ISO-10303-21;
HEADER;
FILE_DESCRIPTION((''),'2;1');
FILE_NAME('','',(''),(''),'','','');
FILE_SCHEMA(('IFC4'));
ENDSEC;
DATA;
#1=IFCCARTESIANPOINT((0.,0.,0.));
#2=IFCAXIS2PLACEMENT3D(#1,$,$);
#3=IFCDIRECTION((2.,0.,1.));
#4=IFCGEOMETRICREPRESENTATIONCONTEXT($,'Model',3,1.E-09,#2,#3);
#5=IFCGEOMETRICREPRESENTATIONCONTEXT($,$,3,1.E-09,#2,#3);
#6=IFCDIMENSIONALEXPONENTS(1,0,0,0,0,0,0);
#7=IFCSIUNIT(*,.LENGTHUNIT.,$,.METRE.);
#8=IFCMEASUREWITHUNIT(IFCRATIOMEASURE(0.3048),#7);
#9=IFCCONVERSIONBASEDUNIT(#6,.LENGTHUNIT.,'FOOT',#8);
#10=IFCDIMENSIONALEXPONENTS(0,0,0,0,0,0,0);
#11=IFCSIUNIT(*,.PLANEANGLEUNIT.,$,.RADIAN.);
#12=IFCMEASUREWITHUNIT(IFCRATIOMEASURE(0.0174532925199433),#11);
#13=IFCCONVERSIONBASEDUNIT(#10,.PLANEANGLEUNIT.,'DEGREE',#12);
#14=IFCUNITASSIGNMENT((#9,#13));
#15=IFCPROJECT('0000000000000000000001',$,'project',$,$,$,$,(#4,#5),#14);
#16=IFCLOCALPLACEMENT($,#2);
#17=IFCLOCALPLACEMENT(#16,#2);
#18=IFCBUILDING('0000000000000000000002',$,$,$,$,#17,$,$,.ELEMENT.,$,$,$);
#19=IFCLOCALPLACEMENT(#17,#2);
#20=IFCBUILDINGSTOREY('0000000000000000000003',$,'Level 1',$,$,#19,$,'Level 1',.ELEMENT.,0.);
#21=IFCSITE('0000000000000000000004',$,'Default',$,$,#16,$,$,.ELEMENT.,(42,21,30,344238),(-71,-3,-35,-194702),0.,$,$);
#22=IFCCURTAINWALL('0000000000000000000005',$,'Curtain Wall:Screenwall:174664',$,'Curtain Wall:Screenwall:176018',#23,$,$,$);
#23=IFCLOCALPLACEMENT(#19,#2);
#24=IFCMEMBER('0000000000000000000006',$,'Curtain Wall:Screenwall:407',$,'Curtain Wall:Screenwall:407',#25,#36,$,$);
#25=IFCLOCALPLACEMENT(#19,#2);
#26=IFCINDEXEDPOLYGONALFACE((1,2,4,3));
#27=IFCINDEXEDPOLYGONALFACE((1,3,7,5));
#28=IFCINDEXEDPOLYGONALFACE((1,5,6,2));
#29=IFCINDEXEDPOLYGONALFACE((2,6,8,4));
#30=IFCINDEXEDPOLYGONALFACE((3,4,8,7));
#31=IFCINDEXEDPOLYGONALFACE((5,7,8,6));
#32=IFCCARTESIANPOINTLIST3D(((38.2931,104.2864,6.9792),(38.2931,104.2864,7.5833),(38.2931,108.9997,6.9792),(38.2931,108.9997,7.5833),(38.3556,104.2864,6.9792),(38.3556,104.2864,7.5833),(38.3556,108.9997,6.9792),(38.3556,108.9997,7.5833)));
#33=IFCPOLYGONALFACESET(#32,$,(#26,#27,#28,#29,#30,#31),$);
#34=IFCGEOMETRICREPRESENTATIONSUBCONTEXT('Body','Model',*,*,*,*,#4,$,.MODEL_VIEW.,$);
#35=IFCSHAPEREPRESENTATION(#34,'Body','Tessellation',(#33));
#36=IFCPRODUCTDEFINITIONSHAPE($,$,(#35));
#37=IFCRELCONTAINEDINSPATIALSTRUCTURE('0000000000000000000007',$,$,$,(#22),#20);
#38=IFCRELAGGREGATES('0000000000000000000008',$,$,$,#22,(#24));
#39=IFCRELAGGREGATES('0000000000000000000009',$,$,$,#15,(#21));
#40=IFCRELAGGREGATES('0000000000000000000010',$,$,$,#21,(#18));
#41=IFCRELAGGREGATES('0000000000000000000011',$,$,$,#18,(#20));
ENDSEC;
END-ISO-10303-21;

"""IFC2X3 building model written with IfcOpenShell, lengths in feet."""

from ifc_helpers import new_model, entity, si_unit, converted_unit, direction, frame, origin, origin_2d_with_axis, place, context, subcontext, project, spatial, rectangle, extrude, element, aggregate, save


model = new_model("IFC2X3")

# Units and contexts
model_context = context("Model", 3, precision=1e-09, world=origin(), true_north=direction((2.0, 0.0, 1.0)))
context_of_model = context(None, 3, precision=1e-09, world=origin(), true_north=direction((2.0, 0.0, 1.0)))
body_context = subcontext(model_context, "Body", "Model", "MODEL_VIEW")
ifc_project = project(units=[converted_unit("LENGTHUNIT", "FOOT", entity("IfcRatioMeasure", 0.3048), si_unit("LENGTHUNIT", "METRE"), dimensions=[1, 0, 0, 0, 0, 0, 0]), converted_unit("PLANEANGLEUNIT", "DEGREE", entity("IfcRatioMeasure", 0.0174532925199433), si_unit("PLANEANGLEUNIT", "RADIAN"), dimensions=[0, 0, 0, 0, 0, 0, 0])], contexts=[model_context, context_of_model])

# Site, building, storey
site_placement = place(None, origin())
site = spatial("IfcSite", under=ifc_project, at=site_placement, Name="Default", CompositionType="ELEMENT", RefLatitude=(42, 21, 30, 344238), RefLongitude=(-71, -3, -35, -194702), RefElevation=0.0)
building_placement = place(site_placement, origin())
building = spatial("IfcBuilding", under=site, at=building_placement, CompositionType="ELEMENT")
storey_placement = place(building_placement, origin())
storey = spatial("IfcBuildingStorey", under=building, at=storey_placement, Name="Level 1", LongName="Level 1", CompositionType="ELEMENT", Elevation=0.0)

# Curtain wall, member
curtain_wall_1_placement = place(storey_placement, origin())
curtain_wall_1 = element("IfcCurtainWall", 1, at=curtain_wall_1_placement, inside=storey, Name="Curtain Wall:Screenwall:174664", ObjectType="Curtain Wall:Screenwall:176018")
member_1_placement = place(curtain_wall_1_placement, frame((38.2931, 104.2864, 6.9792)))
member_1 = element("IfcMember", 2, at=member_1_placement, Name="Curtain Wall:Screenwall:407", ObjectType="Curtain Wall:Screenwall:407", context=body_context, shape_type="SweptSolid", body=[
    extrude(rectangle(XDim=4.7134, YDim=0.0625, at=origin_2d_with_axis()), frame((0.0312, 2.3567, 0.0), z_axis=(0.0, 0.0, 1.0), x_axis=(0.0, 1.0, 0.0)), (0.0, 0.0, 1.0), 0.6042),
])
aggregate(curtain_wall_1, [member_1])

save(model, "model.ifc")
